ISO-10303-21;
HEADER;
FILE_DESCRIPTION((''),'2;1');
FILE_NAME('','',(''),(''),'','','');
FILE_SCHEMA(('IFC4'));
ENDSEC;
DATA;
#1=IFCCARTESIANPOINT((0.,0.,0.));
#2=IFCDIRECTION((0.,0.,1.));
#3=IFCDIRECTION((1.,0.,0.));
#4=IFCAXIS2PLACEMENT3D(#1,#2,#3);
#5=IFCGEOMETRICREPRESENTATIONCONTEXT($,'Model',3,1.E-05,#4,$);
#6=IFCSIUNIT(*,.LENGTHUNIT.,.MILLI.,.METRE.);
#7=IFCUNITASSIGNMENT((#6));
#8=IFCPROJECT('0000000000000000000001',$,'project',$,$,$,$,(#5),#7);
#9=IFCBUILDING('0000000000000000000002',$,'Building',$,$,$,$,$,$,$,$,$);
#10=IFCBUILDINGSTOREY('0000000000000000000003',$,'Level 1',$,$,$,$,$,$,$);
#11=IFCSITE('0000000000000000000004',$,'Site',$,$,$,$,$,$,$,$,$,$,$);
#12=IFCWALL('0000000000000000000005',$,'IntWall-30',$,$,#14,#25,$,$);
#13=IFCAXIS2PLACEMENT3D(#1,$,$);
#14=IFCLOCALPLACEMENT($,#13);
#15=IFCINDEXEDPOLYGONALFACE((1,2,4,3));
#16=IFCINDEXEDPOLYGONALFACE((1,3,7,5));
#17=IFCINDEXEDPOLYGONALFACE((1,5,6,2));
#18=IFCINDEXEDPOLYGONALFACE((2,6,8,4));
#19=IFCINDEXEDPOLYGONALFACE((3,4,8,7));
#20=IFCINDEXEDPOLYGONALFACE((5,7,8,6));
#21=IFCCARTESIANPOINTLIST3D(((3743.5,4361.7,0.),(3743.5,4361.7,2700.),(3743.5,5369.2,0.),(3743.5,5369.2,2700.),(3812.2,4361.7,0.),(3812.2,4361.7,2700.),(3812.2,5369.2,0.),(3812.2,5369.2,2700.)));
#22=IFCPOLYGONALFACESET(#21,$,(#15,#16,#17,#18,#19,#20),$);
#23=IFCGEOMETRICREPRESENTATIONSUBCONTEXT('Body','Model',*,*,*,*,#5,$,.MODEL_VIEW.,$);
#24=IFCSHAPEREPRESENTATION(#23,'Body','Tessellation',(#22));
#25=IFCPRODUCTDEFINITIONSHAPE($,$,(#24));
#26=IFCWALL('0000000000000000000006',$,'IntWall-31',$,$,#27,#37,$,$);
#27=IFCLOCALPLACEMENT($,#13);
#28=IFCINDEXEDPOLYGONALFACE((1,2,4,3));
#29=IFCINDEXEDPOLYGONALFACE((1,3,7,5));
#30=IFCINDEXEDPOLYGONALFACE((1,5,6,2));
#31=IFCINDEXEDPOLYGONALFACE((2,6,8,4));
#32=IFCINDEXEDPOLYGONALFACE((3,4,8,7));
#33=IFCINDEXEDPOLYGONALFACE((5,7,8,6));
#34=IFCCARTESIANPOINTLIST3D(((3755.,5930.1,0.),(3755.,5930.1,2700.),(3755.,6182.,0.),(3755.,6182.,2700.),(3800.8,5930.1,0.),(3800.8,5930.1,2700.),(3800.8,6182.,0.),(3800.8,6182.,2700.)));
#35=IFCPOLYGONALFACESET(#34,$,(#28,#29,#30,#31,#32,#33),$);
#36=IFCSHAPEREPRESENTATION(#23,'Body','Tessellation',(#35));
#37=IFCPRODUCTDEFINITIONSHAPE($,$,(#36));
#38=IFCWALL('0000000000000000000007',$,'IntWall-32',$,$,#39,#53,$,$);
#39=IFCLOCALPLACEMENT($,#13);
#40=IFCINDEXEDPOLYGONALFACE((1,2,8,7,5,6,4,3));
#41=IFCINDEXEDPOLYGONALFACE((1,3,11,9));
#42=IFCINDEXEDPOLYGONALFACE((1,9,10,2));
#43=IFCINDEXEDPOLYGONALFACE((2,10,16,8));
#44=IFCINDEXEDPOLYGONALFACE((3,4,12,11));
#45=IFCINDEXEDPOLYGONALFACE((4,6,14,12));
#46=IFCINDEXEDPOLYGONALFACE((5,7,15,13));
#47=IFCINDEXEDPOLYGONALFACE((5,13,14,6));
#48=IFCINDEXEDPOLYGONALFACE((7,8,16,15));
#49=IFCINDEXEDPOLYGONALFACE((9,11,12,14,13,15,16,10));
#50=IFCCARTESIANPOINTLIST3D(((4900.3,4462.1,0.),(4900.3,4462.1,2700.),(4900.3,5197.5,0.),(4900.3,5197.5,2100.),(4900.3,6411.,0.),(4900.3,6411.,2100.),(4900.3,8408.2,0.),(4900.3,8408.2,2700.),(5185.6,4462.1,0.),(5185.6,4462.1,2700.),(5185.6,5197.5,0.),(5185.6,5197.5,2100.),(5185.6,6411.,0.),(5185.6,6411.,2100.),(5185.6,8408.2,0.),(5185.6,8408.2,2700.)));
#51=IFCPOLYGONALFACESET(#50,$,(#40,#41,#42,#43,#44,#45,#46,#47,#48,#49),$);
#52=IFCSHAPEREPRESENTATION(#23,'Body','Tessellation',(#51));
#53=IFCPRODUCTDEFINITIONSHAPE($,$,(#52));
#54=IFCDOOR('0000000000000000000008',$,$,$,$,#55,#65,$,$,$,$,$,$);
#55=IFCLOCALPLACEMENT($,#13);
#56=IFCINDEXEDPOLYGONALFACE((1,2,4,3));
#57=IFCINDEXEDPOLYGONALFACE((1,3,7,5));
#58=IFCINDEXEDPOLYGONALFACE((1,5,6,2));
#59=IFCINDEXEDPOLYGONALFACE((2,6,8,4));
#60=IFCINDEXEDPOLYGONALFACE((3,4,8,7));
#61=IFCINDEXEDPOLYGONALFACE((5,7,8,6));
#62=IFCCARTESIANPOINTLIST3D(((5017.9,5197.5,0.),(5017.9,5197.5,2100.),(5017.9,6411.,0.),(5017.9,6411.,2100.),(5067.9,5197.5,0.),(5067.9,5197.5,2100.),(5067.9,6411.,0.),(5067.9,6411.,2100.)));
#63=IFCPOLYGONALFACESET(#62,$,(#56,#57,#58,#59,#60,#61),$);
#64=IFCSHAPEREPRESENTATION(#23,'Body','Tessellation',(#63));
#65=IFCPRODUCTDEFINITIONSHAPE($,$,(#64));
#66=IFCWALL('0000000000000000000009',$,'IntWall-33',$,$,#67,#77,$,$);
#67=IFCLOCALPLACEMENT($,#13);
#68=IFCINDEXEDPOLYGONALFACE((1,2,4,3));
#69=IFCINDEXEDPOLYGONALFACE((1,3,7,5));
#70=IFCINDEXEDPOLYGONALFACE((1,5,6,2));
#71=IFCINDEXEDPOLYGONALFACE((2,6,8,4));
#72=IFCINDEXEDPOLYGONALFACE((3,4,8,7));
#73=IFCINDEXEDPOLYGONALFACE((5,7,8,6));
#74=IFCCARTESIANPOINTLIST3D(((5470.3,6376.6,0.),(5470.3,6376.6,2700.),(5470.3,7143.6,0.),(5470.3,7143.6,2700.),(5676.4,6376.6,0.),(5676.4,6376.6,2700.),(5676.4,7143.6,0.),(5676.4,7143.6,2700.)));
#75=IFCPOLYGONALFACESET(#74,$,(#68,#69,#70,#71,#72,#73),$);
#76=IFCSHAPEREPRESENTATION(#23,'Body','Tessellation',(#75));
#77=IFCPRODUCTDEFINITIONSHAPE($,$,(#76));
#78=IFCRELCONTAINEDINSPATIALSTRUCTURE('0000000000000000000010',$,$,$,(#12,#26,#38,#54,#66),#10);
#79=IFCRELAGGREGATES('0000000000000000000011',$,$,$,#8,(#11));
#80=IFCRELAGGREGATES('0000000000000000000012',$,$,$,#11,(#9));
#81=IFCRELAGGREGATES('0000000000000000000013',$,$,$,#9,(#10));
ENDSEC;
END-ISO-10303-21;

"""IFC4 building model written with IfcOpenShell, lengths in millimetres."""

from ifc_helpers import new_model, si_unit, frame, origin_with_axes, place, context, subcontext, project, spatial, indexed_curve, outline, extrude, element, fill, save


model = new_model("IFC4")

# Units and contexts
model_context = context("Model", 3, precision=1e-05, world=origin_with_axes())
body_context = subcontext(model_context, "Body", "Model", "MODEL_VIEW")
ifc_project = project(units=[si_unit("LENGTHUNIT", "METRE", prefix="MILLI")], contexts=[model_context])

# Site, building, storey
site = spatial("IfcSite", under=ifc_project, Name="Site")
building = spatial("IfcBuilding", under=site, Name="Building")
storey = spatial("IfcBuildingStorey", under=building, Name="Level 1")

# Walls
wall_1_placement = place(None, frame((3777.9, 4361.7, 0.0), z_axis=(0.0, 0.0, 1.0), x_axis=(0.0, 1.0, 0.0)))
element("IfcWall", 1, at=wall_1_placement, inside=storey, Name="IntWall-30", context=body_context, shape_type="SweptSolid", body=[
    extrude(outline(indexed_curve([(0.0, 0.0), (0.0, 68.7), (1007.4, 68.7), (1007.4, 0.0), (0.0, 0.0)], self_intersect=False)), frame((0.0, -34.3, 0.0), z_axis=(0.0, 0.0, 1.0), x_axis=(1.0, 0.0, 0.0)), (0.0, 0.0, 1.0), 2700.0),
])
wall_2_placement = place(None, frame((3777.9, 5930.1, 0.0), z_axis=(0.0, 0.0, 1.0), x_axis=(0.0, 1.0, 0.0)))
element("IfcWall", 2, at=wall_2_placement, inside=storey, Name="IntWall-31", context=body_context, shape_type="SweptSolid", body=[
    extrude(outline(indexed_curve([(0.0, 0.0), (0.0, 45.8), (251.9, 45.8), (251.9, 0.0), (0.0, 0.0)], self_intersect=False)), frame((0.0, -22.9, 0.0), z_axis=(0.0, 0.0, 1.0), x_axis=(1.0, 0.0, 0.0)), (0.0, 0.0, 1.0), 2700.0),
])

# Wall, opening, door
wall_3_placement = place(None, frame((5042.9, 4462.1, 0.0), z_axis=(0.0, 0.0, 1.0), x_axis=(0.0, 1.0, 0.0)))
wall_3 = element("IfcWall", 3, at=wall_3_placement, inside=storey, Name="IntWall-32", context=body_context, shape_type="SweptSolid", body=[
    extrude(outline(indexed_curve([(0.0, 0.0), (0.0, 285.3), (3946.2, 285.3), (3946.2, 0.0), (0.0, 0.0)], self_intersect=False)), frame((0.0, -142.6, 0.0), z_axis=(0.0, 0.0, 1.0), x_axis=(1.0, 0.0, 0.0)), (0.0, 0.0, 1.0), 2700.0),
])
opening_1_placement = place(wall_3_placement, frame((735.4, 0.0, 0.0), z_axis=(0.0, 0.0, 1.0), x_axis=(1.0, 0.0, 0.0)))
opening_1 = element("IfcOpeningElement", 4, at=opening_1_placement, cuts=wall_3, context=body_context, shape_type="SweptSolid", body=[
    extrude(outline(indexed_curve([(0.0, 0.0), (0.0, 385.3), (1213.5, 385.3), (1213.5, 0.0), (0.0, 0.0)], self_intersect=False)), frame((0.0, -192.6, 0.0), z_axis=(0.0, 0.0, 1.0), x_axis=(1.0, 0.0, 0.0)), (0.0, 0.0, 1.0), 2100.0),
])
door_1_placement = place(opening_1_placement, frame((0.0, 0.0, 0.0), z_axis=(0.0, 0.0, 1.0), x_axis=(1.0, 0.0, 0.0)))
door_1 = element("IfcDoor", 5, at=door_1_placement, inside=storey, context=body_context, shape_type="SweptSolid", body=[
    extrude(outline(indexed_curve([(0.0, 0.0), (0.0, 50.0), (1213.5, 50.0), (1213.5, 0.0), (0.0, 0.0)], self_intersect=False)), frame((0.0, -25.0, 0.0), z_axis=(0.0, 0.0, 1.0), x_axis=(1.0, 0.0, 0.0)), (0.0, 0.0, 1.0), 2100.0),
])
fill(opening_1, door_1)

# Wall
wall_4_placement = place(None, frame((5573.3, 6376.6, 0.0), z_axis=(0.0, 0.0, 1.0), x_axis=(0.0, 1.0, 0.0)))
element("IfcWall", 6, at=wall_4_placement, inside=storey, Name="IntWall-33", context=body_context, shape_type="SweptSolid", body=[
    extrude(outline(indexed_curve([(0.0, 0.0), (0.0, 206.1), (767.0, 206.1), (767.0, 0.0), (0.0, 0.0)], self_intersect=False)), frame((0.0, -103.0, 0.0), z_axis=(0.0, 0.0, 1.0), x_axis=(1.0, 0.0, 0.0)), (0.0, 0.0, 1.0), 2700.0),
])

save(model, "model.ifc")
